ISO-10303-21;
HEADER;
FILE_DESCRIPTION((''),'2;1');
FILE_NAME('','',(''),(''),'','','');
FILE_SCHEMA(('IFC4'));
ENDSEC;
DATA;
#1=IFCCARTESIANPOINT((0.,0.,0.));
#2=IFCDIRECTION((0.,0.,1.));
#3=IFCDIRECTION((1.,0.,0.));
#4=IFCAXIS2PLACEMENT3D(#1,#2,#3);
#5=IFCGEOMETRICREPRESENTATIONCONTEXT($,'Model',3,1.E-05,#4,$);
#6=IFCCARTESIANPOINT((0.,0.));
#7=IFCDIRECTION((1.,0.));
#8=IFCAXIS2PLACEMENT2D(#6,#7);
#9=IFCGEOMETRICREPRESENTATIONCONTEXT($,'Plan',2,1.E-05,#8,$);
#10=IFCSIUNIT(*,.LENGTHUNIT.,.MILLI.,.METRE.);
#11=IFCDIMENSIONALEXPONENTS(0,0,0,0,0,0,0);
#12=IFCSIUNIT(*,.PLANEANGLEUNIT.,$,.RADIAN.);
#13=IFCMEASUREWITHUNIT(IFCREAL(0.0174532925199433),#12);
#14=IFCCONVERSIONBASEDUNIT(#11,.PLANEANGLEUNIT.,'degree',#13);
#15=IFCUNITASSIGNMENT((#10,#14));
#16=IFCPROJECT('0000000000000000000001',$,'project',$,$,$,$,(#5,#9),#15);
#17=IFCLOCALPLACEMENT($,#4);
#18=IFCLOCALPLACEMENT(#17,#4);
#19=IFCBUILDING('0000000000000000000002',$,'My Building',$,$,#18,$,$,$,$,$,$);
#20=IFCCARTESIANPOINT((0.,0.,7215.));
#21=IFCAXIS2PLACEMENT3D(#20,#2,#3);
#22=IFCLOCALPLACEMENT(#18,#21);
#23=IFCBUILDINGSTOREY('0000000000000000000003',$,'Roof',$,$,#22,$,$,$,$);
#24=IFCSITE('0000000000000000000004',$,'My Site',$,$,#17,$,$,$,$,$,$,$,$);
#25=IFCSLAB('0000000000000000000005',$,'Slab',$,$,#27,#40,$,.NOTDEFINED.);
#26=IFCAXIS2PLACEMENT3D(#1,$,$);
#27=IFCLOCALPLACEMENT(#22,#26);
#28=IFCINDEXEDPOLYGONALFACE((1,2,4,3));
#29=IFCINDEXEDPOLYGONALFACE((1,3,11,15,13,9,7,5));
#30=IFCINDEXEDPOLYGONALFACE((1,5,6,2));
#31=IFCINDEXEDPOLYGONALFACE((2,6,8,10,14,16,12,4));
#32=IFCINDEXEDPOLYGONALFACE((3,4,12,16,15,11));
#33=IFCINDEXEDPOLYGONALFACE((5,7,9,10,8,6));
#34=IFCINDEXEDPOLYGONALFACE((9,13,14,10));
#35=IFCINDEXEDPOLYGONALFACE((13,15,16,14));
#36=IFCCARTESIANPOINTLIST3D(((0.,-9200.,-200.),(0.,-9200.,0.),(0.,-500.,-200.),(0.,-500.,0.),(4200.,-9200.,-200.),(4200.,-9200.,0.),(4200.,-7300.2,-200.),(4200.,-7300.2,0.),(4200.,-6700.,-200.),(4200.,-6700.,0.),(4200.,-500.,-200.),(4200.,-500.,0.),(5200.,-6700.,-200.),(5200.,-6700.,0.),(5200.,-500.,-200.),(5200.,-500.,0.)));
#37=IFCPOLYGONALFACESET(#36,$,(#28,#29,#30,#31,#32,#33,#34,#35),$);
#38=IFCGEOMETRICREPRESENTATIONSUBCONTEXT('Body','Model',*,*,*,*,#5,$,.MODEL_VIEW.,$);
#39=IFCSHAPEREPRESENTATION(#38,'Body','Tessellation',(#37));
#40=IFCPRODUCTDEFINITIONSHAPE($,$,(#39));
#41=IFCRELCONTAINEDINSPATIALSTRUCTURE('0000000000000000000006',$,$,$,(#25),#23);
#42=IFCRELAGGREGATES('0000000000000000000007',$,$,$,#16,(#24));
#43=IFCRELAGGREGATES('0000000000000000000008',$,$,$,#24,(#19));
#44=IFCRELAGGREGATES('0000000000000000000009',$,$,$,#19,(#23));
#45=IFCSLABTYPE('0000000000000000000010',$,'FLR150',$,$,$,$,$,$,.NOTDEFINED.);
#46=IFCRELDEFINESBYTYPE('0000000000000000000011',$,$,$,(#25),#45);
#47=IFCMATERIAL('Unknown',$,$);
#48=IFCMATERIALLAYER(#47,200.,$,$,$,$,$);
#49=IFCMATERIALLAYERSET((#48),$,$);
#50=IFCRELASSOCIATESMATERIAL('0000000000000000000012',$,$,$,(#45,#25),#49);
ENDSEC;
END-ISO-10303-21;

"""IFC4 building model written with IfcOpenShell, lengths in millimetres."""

from ifc_helpers import new_model, entity, si_unit, converted_unit, frame, origin_with_axes, origin_2d_with_axis, place, context, subcontext, project, spatial, line, indexed_curve, outline, extrude, material, layer, layer_set, layer_usage, type_object, element, save


model = new_model("IFC4")

# Units and contexts
model_context = context("Model", 3, precision=1e-05, world=origin_with_axes())
plan_context = context("Plan", 2, precision=1e-05, world=origin_2d_with_axis())
body_context = subcontext(model_context, "Body", "Model", "MODEL_VIEW")
ifc_project = project(units=[si_unit("LENGTHUNIT", "METRE", prefix="MILLI"), converted_unit("PLANEANGLEUNIT", "degree", entity("IfcReal", 0.0174532925199433), si_unit("PLANEANGLEUNIT", "RADIAN"), dimensions=[0, 0, 0, 0, 0, 0, 0])], contexts=[model_context, plan_context])

# Site, building, storey
site_placement = place(None, origin_with_axes())
site = spatial("IfcSite", under=ifc_project, at=site_placement, Name="My Site")
building_placement = place(site_placement, origin_with_axes())
building = spatial("IfcBuilding", under=site, at=building_placement, Name="My Building")
storey_placement = place(building_placement, frame((0.0, 0.0, 7215.0), z_axis=(0.0, 0.0, 1.0), x_axis=(1.0, 0.0, 0.0)))
storey = spatial("IfcBuildingStorey", under=building, at=storey_placement, Name="Roof")

# Slab
ifc_material = material(Name="Unknown")
ifc_layer = layer(ifc_material, 200.0)
ifc_layer_set = layer_set([ifc_layer])
ifc_layer_usage = layer_usage(ifc_layer_set, "AXIS3", "POSITIVE", 0.0)
slab_type = type_object("IfcSlabType", Name="FLR150", PredefinedType="NOTDEFINED", material=ifc_layer_set)
slab_placement = place(storey_placement, frame((0.0, -9200.0, -200.0), z_axis=(0.0, 0.0, 1.0), x_axis=(1.0, 0.0, 0.0)))
element("IfcSlab", 1, at=slab_placement, inside=storey, type_object=slab_type, material=ifc_layer_usage, Name="Slab", PredefinedType="NOTDEFINED", context=body_context, shape_type="SweptSolid", body=[
    extrude(outline(indexed_curve([(4200.0, 1899.8), (4200.0, 2500.0), (5200.0, 2500.0), (5200.0, 8700.0), (4200.0, 8700.0), (0.0, 8700.0), (0.0, 0.0), (4200.0, 0.0)], segments=[line(8, 7), line(7, 6), line(6, 5), line(5, 4), line(4, 3), line(3, 2), line(2, 1), line(1, 8)], self_intersect=False)), None, (0.0, 0.0, 1.0), 200.0),
])

save(model, "model.ifc")
